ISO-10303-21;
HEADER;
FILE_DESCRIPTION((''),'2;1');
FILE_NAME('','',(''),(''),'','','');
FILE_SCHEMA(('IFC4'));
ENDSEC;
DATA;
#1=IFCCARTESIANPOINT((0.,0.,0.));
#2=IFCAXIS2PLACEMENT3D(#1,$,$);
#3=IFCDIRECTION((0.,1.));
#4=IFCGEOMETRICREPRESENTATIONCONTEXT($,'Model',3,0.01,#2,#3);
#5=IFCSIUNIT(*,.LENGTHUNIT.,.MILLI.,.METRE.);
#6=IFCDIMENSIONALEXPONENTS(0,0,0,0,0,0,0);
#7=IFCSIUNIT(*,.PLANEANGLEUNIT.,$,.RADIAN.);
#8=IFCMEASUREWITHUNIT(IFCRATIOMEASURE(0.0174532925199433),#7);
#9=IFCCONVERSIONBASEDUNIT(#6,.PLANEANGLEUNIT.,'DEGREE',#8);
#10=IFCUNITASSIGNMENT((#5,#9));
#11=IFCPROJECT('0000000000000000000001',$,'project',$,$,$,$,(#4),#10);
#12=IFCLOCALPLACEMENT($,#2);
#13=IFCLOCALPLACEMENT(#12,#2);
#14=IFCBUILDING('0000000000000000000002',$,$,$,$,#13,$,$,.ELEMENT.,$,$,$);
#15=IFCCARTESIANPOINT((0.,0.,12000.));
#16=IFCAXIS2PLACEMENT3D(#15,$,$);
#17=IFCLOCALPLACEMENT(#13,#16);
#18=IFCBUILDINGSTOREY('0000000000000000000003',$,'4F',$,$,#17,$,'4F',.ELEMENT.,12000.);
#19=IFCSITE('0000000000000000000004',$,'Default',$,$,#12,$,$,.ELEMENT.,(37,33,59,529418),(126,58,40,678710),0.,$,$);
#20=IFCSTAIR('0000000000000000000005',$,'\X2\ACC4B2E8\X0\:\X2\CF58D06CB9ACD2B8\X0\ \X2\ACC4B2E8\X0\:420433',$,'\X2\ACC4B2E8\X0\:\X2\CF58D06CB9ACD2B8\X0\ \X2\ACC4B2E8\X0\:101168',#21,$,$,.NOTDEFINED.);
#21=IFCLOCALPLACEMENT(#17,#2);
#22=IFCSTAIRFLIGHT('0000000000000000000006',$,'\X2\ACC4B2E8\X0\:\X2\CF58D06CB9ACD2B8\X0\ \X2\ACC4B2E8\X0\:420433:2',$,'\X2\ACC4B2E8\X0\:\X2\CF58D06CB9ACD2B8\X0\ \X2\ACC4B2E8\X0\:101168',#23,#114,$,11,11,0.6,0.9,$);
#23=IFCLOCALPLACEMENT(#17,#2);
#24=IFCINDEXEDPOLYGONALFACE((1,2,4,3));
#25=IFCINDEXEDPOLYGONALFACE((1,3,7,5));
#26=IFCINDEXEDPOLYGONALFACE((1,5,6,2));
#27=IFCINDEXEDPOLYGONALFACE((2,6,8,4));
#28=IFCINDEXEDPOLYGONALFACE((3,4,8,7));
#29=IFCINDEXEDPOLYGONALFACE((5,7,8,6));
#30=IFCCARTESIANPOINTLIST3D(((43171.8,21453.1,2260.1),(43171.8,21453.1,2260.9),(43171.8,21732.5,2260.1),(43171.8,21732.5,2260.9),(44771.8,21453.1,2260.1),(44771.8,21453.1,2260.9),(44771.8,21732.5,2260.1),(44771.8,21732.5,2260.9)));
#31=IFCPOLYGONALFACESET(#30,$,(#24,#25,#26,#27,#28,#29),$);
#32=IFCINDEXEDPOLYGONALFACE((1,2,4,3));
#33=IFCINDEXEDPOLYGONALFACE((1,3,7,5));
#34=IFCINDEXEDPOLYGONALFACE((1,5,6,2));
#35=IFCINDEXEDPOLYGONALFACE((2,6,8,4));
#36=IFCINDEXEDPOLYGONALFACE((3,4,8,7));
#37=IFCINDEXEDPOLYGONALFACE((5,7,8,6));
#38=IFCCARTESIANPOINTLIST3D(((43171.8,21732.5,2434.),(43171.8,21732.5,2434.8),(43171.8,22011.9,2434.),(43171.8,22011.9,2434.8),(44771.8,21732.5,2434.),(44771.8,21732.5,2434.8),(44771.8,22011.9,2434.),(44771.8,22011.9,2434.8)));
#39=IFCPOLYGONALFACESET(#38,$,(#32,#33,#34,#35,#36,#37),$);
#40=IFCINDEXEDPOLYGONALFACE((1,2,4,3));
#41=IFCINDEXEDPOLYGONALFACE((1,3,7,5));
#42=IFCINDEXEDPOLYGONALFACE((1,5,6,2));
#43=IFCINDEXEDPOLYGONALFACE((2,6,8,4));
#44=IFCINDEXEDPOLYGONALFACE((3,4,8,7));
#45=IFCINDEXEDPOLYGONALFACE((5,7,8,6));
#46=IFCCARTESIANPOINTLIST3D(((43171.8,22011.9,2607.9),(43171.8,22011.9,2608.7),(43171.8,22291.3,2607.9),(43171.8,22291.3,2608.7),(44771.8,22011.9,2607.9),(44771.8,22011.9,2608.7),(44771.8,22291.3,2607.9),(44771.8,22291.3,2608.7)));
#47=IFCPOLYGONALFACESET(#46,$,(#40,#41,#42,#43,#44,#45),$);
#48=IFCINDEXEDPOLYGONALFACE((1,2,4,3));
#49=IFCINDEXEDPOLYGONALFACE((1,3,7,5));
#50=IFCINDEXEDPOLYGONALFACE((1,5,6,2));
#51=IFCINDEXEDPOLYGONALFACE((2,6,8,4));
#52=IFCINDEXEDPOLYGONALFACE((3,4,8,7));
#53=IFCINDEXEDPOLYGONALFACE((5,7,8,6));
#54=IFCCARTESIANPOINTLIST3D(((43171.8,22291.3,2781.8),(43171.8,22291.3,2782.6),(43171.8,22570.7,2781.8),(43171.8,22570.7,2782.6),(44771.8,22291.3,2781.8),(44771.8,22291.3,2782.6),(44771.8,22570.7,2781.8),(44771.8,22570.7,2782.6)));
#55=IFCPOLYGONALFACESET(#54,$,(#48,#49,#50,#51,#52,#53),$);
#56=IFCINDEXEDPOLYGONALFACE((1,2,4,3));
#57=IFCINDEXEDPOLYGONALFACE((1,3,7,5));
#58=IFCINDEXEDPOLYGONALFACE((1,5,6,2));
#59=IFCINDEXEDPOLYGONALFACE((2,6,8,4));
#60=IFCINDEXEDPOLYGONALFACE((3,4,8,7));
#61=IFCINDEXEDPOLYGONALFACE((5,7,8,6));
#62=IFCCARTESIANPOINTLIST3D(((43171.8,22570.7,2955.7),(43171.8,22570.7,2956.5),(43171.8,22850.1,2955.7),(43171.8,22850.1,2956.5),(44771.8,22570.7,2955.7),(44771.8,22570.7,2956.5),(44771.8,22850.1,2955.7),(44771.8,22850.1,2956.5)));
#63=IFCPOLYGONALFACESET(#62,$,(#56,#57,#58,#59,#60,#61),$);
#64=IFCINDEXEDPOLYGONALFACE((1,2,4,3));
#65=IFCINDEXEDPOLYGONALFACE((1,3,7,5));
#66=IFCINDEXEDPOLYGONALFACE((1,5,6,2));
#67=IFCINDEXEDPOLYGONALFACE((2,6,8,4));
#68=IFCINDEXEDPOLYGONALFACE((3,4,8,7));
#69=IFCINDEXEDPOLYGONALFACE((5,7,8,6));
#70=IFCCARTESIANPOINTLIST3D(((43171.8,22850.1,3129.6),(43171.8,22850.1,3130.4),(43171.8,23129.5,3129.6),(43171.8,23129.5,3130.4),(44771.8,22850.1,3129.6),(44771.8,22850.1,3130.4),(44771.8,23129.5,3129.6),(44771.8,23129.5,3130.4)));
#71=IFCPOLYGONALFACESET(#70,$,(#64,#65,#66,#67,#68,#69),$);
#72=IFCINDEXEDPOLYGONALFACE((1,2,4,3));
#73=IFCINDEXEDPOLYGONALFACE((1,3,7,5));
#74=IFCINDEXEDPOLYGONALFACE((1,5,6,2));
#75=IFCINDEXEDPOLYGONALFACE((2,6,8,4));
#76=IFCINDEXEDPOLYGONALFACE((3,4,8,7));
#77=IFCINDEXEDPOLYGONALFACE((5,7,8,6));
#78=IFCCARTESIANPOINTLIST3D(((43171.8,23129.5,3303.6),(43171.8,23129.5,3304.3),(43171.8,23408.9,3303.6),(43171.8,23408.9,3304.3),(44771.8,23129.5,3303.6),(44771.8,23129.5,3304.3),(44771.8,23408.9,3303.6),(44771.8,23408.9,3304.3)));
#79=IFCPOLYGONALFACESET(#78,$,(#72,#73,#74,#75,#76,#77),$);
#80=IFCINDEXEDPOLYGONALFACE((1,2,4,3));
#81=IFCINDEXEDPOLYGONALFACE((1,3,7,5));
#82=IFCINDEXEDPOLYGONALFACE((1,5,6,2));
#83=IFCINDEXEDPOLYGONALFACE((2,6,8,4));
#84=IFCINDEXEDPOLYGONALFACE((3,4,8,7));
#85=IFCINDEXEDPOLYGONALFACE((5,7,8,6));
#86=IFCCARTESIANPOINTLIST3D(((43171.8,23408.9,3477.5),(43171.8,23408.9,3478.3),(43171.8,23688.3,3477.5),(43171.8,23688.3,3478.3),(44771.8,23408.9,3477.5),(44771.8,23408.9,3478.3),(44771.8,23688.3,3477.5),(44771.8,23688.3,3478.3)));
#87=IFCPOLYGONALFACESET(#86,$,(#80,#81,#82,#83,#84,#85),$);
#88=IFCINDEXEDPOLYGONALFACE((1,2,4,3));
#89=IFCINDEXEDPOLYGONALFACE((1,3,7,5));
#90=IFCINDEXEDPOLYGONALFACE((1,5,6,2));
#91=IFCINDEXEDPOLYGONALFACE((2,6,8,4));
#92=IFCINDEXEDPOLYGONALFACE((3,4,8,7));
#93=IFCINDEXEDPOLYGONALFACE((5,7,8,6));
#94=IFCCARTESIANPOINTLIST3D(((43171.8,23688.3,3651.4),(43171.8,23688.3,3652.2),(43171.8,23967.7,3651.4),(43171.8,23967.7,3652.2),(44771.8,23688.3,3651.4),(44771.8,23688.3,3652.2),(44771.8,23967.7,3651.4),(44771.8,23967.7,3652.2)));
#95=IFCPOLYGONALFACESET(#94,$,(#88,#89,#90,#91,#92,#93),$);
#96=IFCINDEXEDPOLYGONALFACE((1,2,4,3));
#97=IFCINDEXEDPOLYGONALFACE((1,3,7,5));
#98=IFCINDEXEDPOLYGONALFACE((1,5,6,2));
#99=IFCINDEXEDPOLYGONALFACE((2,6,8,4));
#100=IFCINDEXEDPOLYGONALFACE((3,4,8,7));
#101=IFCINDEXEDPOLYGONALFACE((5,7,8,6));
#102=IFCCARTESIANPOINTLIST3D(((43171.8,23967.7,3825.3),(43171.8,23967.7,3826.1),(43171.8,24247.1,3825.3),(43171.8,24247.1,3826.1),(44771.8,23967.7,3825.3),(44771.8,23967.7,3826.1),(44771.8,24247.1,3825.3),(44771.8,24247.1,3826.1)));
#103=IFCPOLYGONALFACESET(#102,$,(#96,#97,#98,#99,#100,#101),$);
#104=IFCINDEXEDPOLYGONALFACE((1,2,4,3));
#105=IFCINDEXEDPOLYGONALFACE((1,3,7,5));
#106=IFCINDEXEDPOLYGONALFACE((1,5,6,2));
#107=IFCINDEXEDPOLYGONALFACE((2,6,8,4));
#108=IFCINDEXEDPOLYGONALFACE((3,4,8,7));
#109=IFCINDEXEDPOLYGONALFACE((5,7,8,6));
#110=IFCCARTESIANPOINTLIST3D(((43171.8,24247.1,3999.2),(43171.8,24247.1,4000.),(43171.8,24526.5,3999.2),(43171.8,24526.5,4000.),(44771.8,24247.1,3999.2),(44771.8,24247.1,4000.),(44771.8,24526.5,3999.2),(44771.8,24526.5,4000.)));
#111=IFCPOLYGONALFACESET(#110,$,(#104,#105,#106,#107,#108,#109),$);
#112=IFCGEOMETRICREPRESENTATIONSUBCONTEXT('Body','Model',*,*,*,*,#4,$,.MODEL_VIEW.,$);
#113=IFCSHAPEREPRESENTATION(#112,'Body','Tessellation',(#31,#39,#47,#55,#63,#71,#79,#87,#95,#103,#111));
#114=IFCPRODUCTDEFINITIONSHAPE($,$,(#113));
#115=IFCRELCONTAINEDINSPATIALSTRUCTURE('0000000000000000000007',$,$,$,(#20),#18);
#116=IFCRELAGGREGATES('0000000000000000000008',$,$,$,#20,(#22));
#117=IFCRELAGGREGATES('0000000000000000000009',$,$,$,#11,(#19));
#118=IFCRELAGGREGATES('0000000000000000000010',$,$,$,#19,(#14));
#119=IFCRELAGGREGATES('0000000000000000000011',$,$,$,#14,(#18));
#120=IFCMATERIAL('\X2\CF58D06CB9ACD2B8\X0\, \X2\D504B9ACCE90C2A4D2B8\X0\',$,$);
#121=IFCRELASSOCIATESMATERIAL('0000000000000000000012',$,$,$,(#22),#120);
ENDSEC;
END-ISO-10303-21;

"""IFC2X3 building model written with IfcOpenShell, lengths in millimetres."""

from ifc_helpers import new_model, entity, si_unit, converted_unit, direction, frame, frame_2d, origin, place, context, subcontext, project, spatial, rectangle, extrude, material, element, aggregate, save


model = new_model("IFC2X3")

# Units and contexts
model_context = context("Model", 3, precision=0.01, world=origin(), true_north=direction((0.0, 1.0)))
body_context = subcontext(model_context, "Body", "Model", "MODEL_VIEW")
ifc_project = project(units=[si_unit("LENGTHUNIT", "METRE", prefix="MILLI"), converted_unit("PLANEANGLEUNIT", "DEGREE", entity("IfcRatioMeasure", 0.0174532925199433), si_unit("PLANEANGLEUNIT", "RADIAN"), dimensions=[0, 0, 0, 0, 0, 0, 0])], contexts=[model_context])

# Site, building, storey
site_placement = place(None, origin())
site = spatial("IfcSite", under=ifc_project, at=site_placement, Name="Default", CompositionType="ELEMENT", RefLatitude=(37, 33, 59, 529418), RefLongitude=(126, 58, 40, 678710), RefElevation=0.0)
building_placement = place(site_placement, origin())
building = spatial("IfcBuilding", under=site, at=building_placement, CompositionType="ELEMENT")
storey_placement = place(building_placement, frame((0.0, 0.0, 12000.0)))
storey = spatial("IfcBuildingStorey", under=building, at=storey_placement, Name="4F", LongName="4F", CompositionType="ELEMENT", Elevation=12000.0)

# Stair
stair_placement = place(storey_placement, origin())
stair = element("IfcStair", 1, at=stair_placement, inside=storey, Name="계단:콘크리트 계단:420433", ObjectType="계단:콘크리트 계단:101168", ShapeType="NOTDEFINED")
ifc_material_1 = material(Name="콘크리트, 프리캐스트")

# Stair flight
stair_flight_placement = place(stair_placement, origin())
stair_flight = element("IfcStairFlight", 2, at=stair_flight_placement, material=ifc_material_1, Name="계단:콘크리트 계단:420433:2", ObjectType="계단:콘크리트 계단:101168", NumberOfRiser=11, NumberOfTreads=11, RiserHeight=0.6, TreadLength=0.9, context=body_context, shape_type="SweptSolid", body=[
    extrude(rectangle(XDim=279.4, YDim=1600.0, at=frame_2d((0.0, 0.0), x_axis=(1.0, 0.0))), frame((43971.8, 21592.8, 2260.1), z_axis=(0.0, 0.0, 1.0), x_axis=(0.0, -1.0, 0.0)), (0.0, 0.0, 1.0), 0.8),
    extrude(rectangle(XDim=279.4, YDim=1600.0, at=frame_2d((0.0, 0.0), x_axis=(1.0, 0.0))), frame((43971.8, 21872.2, 2434.0), z_axis=(0.0, 0.0, 1.0), x_axis=(0.0, -1.0, 0.0)), (0.0, 0.0, 1.0), 0.8),
    extrude(rectangle(XDim=279.4, YDim=1600.0, at=frame_2d((0.0, 0.0), x_axis=(1.0, 0.0))), frame((43971.8, 22151.6, 2607.9), z_axis=(0.0, 0.0, 1.0), x_axis=(0.0, -1.0, 0.0)), (0.0, 0.0, 1.0), 0.8),
    extrude(rectangle(XDim=279.4, YDim=1600.0, at=frame_2d((0.0, 0.0), x_axis=(1.0, 0.0))), frame((43971.8, 22431.0, 2781.8), z_axis=(0.0, 0.0, 1.0), x_axis=(0.0, -1.0, 0.0)), (0.0, 0.0, 1.0), 0.8),
    extrude(rectangle(XDim=279.4, YDim=1600.0, at=frame_2d((0.0, 0.0), x_axis=(1.0, 0.0))), frame((43971.8, 22710.4, 2955.7), z_axis=(0.0, 0.0, 1.0), x_axis=(0.0, -1.0, 0.0)), (0.0, 0.0, 1.0), 0.8),
    extrude(rectangle(XDim=279.4, YDim=1600.0, at=frame_2d((0.0, 0.0), x_axis=(1.0, 0.0))), frame((43971.8, 22989.8, 3129.6), z_axis=(0.0, 0.0, 1.0), x_axis=(0.0, -1.0, 0.0)), (0.0, 0.0, 1.0), 0.8),
    extrude(rectangle(XDim=279.4, YDim=1600.0, at=frame_2d((0.0, 0.0), x_axis=(1.0, 0.0))), frame((43971.8, 23269.2, 3303.6), z_axis=(0.0, 0.0, 1.0), x_axis=(0.0, -1.0, 0.0)), (0.0, 0.0, 1.0), 0.8),
    extrude(rectangle(XDim=279.4, YDim=1600.0, at=frame_2d((0.0, 0.0), x_axis=(1.0, 0.0))), frame((43971.8, 23548.6, 3477.5), z_axis=(0.0, 0.0, 1.0), x_axis=(0.0, -1.0, 0.0)), (0.0, 0.0, 1.0), 0.8),
    extrude(rectangle(XDim=279.4, YDim=1600.0, at=frame_2d((0.0, 0.0), x_axis=(1.0, 0.0))), frame((43971.8, 23828.0, 3651.4), z_axis=(0.0, 0.0, 1.0), x_axis=(0.0, -1.0, 0.0)), (0.0, 0.0, 1.0), 0.8),
    extrude(rectangle(XDim=279.4, YDim=1600.0, at=frame_2d((0.0, 0.0), x_axis=(1.0, 0.0))), frame((43971.8, 24107.4, 3825.3), z_axis=(0.0, 0.0, 1.0), x_axis=(0.0, -1.0, 0.0)), (0.0, 0.0, 1.0), 0.8),
    extrude(rectangle(XDim=279.4, YDim=1600.0, at=frame_2d((0.0, 0.0), x_axis=(1.0, 0.0))), frame((43971.8, 24386.8, 3999.2), z_axis=(0.0, 0.0, 1.0), x_axis=(0.0, -1.0, 0.0)), (0.0, 0.0, 1.0), 0.8),
])
aggregate(stair, [stair_flight])

save(model, "model.ifc")
